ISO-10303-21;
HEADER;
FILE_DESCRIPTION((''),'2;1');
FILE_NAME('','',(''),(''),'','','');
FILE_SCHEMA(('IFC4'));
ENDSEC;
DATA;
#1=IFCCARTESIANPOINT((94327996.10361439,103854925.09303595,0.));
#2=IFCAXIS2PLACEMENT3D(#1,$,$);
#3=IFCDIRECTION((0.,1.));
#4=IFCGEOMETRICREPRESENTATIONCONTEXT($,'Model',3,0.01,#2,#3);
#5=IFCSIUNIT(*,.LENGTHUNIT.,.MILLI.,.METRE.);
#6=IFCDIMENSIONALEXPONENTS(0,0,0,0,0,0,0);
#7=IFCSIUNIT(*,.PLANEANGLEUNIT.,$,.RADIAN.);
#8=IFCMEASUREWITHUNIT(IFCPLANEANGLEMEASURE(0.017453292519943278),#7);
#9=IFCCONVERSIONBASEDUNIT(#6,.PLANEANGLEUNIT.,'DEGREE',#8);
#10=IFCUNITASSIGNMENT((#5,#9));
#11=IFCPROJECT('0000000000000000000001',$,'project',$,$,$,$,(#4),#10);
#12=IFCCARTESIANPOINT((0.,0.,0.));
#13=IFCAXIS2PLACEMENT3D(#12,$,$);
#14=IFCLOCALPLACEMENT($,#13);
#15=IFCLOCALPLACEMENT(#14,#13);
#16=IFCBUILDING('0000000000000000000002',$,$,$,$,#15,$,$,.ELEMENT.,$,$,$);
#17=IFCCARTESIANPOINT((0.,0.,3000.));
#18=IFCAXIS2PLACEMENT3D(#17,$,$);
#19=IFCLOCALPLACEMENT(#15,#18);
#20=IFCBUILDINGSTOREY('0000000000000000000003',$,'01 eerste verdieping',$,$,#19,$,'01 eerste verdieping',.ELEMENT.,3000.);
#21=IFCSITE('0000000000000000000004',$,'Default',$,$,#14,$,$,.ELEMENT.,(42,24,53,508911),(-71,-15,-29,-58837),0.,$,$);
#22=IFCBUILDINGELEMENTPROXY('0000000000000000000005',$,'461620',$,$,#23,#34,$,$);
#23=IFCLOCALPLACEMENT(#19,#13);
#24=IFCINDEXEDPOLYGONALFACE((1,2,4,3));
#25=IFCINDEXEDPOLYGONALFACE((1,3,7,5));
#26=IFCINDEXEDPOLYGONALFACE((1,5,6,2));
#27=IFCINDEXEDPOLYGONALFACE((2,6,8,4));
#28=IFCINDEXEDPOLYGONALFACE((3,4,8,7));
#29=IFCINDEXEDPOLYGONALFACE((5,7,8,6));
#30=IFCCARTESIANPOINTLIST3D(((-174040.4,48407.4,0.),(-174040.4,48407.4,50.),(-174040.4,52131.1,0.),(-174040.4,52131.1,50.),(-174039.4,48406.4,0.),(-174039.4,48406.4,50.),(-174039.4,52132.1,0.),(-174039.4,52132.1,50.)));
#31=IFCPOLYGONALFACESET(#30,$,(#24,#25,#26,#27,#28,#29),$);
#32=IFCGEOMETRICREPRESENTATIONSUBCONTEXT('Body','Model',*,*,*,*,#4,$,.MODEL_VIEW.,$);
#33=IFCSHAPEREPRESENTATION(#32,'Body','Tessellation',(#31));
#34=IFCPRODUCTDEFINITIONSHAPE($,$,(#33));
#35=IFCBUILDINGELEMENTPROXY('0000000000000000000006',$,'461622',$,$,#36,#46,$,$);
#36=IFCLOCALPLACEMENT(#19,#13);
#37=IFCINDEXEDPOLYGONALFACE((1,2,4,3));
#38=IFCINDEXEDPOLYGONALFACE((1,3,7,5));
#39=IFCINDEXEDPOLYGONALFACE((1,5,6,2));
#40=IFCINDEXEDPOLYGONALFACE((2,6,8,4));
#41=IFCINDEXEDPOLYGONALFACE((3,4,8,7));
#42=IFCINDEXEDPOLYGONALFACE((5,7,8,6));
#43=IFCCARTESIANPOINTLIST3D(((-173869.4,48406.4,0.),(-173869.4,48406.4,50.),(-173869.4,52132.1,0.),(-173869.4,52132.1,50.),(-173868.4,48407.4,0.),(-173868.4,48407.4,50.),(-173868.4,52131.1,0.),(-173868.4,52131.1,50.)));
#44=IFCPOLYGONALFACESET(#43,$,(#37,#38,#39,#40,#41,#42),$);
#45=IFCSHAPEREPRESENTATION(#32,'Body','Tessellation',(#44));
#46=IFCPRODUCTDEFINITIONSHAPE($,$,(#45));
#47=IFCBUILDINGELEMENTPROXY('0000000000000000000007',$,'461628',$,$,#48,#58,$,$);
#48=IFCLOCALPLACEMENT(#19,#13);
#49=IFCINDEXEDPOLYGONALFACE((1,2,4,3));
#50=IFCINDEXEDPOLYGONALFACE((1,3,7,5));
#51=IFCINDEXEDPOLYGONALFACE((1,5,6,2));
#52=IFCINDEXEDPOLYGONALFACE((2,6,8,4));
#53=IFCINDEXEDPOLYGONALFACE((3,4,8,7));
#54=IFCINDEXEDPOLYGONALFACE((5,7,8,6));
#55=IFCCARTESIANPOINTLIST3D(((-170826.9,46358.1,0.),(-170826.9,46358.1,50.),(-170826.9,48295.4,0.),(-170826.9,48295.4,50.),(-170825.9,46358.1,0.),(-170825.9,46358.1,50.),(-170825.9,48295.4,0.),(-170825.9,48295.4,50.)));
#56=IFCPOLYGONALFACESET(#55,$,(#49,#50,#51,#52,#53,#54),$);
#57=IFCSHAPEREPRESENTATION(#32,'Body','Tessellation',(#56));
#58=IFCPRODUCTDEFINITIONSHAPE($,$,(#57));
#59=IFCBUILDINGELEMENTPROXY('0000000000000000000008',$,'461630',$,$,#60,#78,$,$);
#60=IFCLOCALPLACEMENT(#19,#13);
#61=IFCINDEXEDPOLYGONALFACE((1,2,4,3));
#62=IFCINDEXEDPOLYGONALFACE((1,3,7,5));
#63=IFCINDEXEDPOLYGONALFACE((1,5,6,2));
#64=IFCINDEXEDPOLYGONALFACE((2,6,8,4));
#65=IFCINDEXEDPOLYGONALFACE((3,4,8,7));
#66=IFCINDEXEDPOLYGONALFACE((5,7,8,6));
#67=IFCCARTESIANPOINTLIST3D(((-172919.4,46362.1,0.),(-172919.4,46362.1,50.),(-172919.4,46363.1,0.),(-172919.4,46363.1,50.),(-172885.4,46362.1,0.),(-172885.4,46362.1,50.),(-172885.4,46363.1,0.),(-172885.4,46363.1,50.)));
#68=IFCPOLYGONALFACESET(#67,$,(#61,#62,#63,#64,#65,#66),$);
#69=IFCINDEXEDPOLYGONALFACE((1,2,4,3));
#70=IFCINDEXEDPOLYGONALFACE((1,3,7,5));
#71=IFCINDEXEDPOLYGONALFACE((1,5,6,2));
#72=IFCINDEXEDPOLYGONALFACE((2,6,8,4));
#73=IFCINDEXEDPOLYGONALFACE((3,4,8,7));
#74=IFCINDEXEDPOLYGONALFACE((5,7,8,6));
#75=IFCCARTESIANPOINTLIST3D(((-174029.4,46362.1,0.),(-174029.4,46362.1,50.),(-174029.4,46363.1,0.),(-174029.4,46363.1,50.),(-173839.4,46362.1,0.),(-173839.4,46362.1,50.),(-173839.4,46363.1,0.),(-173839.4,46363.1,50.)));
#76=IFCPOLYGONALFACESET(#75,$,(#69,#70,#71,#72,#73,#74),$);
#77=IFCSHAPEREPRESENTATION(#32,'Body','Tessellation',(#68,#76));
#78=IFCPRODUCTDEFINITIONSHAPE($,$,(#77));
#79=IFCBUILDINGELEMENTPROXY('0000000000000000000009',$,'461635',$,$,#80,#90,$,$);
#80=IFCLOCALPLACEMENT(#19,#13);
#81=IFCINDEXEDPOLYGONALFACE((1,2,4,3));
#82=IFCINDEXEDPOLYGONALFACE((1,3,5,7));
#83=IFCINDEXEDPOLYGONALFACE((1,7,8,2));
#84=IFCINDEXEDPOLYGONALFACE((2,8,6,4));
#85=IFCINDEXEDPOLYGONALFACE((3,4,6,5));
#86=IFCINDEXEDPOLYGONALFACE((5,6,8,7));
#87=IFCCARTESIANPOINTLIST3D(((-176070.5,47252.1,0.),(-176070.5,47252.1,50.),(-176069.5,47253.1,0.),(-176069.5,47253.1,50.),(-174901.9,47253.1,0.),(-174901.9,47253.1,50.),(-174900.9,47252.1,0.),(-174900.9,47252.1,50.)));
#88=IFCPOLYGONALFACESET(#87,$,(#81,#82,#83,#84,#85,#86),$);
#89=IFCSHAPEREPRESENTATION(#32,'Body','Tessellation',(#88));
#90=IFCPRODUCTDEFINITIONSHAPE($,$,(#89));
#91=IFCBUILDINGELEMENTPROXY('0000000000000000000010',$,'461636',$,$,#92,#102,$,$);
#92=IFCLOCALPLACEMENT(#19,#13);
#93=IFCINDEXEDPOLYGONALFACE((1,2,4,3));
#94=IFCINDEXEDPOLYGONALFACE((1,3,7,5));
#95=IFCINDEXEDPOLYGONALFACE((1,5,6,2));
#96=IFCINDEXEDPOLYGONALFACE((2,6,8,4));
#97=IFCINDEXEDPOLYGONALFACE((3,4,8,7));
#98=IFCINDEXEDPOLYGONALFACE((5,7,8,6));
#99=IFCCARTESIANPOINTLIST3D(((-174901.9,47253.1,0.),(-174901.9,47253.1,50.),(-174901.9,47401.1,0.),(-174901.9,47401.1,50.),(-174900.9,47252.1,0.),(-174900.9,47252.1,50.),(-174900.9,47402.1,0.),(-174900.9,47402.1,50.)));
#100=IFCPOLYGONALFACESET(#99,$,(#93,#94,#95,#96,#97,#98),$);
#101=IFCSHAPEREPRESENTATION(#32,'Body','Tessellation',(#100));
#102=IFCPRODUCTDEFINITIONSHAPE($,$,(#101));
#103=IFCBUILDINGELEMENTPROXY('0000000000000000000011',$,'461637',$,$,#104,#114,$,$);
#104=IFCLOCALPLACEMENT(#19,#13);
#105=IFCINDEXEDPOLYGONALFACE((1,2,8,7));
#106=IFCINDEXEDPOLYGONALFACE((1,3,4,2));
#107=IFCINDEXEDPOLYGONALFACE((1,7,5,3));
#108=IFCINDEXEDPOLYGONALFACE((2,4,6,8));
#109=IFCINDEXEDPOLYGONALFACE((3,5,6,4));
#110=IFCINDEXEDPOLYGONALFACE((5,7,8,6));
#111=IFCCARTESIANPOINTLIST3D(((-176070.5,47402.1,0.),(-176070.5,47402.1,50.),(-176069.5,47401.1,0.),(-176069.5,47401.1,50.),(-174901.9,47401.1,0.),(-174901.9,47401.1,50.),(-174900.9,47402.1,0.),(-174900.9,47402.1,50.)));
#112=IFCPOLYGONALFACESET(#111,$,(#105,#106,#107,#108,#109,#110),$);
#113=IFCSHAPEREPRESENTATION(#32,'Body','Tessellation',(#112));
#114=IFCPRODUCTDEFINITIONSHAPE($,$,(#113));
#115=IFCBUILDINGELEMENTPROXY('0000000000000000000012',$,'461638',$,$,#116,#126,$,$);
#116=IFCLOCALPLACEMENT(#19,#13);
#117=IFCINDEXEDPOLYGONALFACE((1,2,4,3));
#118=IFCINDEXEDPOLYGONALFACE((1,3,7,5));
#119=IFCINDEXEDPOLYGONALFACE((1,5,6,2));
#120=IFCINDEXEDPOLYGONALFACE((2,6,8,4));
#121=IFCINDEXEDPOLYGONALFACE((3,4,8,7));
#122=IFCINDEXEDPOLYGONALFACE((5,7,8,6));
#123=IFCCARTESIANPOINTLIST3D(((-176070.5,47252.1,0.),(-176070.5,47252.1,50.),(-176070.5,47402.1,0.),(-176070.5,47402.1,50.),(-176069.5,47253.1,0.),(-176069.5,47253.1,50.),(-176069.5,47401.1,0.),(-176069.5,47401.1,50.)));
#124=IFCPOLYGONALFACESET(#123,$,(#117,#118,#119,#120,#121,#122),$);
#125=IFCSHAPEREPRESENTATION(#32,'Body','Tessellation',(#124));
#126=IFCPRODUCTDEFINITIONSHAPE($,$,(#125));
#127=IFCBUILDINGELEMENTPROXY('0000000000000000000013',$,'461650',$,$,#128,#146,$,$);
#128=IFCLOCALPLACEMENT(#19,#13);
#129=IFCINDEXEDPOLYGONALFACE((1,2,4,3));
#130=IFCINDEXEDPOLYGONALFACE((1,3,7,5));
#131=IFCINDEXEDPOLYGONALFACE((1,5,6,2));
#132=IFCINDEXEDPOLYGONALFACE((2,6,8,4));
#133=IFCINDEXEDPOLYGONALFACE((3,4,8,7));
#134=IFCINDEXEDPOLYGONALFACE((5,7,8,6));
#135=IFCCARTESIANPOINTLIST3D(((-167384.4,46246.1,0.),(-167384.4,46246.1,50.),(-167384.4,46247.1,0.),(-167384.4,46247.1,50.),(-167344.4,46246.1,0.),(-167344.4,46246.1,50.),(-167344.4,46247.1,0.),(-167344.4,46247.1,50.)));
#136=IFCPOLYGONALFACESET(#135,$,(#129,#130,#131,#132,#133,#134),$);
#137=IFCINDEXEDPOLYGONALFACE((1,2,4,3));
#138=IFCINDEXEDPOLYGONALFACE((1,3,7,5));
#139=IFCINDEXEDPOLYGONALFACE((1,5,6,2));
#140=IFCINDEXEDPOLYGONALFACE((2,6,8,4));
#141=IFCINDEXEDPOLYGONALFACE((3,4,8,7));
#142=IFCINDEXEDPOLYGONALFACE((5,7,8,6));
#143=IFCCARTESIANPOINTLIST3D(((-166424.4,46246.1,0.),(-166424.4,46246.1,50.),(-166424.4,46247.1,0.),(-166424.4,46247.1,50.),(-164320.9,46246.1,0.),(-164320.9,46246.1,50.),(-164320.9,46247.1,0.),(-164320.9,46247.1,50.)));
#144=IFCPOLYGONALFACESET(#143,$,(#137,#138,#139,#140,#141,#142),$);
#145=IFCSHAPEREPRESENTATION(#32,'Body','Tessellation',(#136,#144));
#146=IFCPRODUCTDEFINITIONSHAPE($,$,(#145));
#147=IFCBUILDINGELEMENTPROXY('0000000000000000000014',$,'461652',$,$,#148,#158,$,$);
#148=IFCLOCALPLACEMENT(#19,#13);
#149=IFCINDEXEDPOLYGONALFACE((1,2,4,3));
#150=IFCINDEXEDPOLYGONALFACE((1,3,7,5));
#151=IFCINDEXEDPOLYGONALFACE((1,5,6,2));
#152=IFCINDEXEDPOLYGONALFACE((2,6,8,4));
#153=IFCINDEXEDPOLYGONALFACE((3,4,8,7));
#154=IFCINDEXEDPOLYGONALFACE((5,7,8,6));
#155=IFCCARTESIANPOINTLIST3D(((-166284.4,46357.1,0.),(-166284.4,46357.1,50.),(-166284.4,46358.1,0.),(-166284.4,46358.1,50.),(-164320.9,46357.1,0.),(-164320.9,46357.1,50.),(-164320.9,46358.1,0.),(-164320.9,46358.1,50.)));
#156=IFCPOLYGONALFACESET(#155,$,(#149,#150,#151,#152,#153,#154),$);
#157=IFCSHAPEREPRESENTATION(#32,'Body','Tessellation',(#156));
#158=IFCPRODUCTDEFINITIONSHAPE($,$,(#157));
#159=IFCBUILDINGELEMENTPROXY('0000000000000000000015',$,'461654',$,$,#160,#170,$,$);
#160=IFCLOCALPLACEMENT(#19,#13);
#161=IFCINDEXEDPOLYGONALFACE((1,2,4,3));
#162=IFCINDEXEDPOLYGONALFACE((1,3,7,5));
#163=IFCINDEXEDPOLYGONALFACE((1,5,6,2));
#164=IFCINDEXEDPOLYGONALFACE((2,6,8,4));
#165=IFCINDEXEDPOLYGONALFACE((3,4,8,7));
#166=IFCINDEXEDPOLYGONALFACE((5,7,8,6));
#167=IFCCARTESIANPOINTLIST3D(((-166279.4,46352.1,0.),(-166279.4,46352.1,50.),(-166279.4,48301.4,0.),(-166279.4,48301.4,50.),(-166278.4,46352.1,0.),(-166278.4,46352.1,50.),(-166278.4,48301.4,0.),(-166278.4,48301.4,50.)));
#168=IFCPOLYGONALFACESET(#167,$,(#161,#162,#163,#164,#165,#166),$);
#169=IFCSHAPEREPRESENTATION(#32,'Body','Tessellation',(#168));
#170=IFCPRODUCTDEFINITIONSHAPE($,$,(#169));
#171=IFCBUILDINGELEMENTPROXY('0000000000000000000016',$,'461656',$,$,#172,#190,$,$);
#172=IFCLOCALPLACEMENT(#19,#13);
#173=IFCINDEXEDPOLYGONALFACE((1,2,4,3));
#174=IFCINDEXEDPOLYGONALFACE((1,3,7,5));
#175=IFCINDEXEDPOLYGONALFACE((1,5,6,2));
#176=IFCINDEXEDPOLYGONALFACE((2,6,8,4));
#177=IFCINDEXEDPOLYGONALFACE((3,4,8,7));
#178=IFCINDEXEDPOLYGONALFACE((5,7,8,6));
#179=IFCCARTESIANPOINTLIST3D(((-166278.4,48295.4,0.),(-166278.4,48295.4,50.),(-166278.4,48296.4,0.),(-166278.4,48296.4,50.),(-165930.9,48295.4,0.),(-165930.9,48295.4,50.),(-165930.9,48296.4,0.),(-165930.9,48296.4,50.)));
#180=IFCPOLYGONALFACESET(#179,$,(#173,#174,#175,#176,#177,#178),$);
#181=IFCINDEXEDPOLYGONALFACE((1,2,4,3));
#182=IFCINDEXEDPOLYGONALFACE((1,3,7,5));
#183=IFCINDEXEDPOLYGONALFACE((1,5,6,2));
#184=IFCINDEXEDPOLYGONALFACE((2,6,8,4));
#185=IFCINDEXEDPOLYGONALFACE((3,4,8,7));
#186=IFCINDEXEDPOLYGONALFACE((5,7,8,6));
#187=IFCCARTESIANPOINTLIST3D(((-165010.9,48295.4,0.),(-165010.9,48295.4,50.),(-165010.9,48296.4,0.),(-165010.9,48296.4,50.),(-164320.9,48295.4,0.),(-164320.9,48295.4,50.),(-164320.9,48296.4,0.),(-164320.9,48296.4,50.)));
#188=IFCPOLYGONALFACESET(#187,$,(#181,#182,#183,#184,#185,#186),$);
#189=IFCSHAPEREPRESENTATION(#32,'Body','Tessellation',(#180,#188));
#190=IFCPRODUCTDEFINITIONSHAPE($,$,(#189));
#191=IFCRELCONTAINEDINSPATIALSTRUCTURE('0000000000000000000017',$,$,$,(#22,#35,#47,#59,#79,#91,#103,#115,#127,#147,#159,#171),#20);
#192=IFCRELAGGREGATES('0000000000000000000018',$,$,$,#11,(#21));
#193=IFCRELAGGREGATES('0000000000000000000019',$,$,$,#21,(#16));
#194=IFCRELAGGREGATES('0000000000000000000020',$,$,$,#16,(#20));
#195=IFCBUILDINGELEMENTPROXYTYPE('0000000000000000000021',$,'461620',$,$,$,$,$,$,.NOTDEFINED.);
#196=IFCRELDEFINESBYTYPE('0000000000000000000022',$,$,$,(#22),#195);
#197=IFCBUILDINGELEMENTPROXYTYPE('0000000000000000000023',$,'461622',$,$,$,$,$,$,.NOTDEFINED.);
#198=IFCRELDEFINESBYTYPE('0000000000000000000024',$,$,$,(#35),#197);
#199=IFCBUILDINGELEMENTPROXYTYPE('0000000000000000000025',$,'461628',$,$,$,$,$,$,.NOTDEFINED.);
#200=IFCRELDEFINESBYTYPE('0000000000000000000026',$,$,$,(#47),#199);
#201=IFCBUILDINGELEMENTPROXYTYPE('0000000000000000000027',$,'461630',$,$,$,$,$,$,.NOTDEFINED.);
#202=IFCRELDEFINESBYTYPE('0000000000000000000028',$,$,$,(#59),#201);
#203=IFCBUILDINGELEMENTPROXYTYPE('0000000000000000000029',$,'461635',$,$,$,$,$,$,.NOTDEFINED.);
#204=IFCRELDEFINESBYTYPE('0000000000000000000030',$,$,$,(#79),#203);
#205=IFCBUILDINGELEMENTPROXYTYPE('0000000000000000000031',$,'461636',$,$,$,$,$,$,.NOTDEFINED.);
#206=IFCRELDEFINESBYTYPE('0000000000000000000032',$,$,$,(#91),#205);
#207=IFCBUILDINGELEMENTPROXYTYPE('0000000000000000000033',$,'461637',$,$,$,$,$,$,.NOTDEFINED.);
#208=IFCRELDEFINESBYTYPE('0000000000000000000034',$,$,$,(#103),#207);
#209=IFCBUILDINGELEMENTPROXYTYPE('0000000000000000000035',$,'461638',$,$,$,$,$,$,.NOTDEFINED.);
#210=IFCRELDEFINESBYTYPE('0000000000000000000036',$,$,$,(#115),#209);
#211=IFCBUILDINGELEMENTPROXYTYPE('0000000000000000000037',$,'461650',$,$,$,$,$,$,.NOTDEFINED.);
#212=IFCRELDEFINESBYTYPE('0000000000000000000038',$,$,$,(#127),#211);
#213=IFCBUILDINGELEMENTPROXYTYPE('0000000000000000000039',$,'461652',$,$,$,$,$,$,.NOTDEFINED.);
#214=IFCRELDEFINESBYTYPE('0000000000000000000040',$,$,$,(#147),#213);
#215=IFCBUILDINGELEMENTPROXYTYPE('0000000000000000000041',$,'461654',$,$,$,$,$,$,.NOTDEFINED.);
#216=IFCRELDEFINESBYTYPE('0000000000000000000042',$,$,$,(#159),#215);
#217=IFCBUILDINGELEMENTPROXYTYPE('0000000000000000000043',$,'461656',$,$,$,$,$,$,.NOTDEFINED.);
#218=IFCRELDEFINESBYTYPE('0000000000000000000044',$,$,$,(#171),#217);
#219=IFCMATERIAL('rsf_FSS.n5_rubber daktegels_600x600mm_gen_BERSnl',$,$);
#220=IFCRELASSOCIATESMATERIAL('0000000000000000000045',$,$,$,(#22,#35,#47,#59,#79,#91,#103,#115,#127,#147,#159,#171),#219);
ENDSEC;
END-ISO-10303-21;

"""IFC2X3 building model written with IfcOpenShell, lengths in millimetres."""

from ifc_helpers import new_model, entity, si_unit, converted_unit, direction, frame, frame_2d, origin, origin_2d_with_axis, place, context, subcontext, project, spatial, polyline, rectangle, outline, extrude, material, type_object, element, save


model = new_model("IFC2X3")

# Units and contexts
model_context = context("Model", 3, precision=0.01, world=frame((94327996.10361439, 103854925.09303595, 0.0)), true_north=direction((0.0, 1.0)))
body_context = subcontext(model_context, "Body", "Model", "MODEL_VIEW")
ifc_project = project(units=[si_unit("LENGTHUNIT", "METRE", prefix="MILLI"), converted_unit("PLANEANGLEUNIT", "DEGREE", entity("IfcPlaneAngleMeasure", 0.017453292519943278), si_unit("PLANEANGLEUNIT", "RADIAN"), dimensions=[0, 0, 0, 0, 0, 0, 0])], contexts=[model_context])

# Site, building, storey
site_placement = place(None, origin())
site = spatial("IfcSite", under=ifc_project, at=site_placement, Name="Default", CompositionType="ELEMENT", RefLatitude=(42, 24, 53, 508911), RefLongitude=(-71, -15, -29, -58837), RefElevation=0.0)
building_placement = place(site_placement, origin())
building = spatial("IfcBuilding", under=site, at=building_placement, CompositionType="ELEMENT")
storey_placement = place(building_placement, frame((0.0, 0.0, 3000.0)))
storey = spatial("IfcBuildingStorey", under=building, at=storey_placement, Name="01 eerste verdieping", LongName="01 eerste verdieping", CompositionType="ELEMENT", Elevation=3000.0)

# Building element proxies
ifc_material = material(Name="rsf_FSS.n5_rubber daktegels_600x600mm_gen_BERSnl")
building_element_proxy_type_1 = type_object("IfcBuildingElementProxyType", Name="461620", PredefinedType="NOTDEFINED")
proxy_1_placement = place(storey_placement, origin())
element("IfcBuildingElementProxy", 1, at=proxy_1_placement, inside=storey, type_object=building_element_proxy_type_1, material=ifc_material, Name="461620", context=body_context, shape_type="SweptSolid", body=[
    extrude(outline(polyline([(-1861.8, -0.5), (1861.8, -0.5), (1862.8, 0.5), (-1862.8, 0.5), (-1861.8, -0.5)])), frame((-174039.9, 50269.2, 0.0), z_axis=(0.0, 0.0, 1.0), x_axis=(0.0, -1.0, 0.0)), (0.0, 0.0, 1.0), 50.0),
])
building_element_proxy_type_2 = type_object("IfcBuildingElementProxyType", Name="461622", PredefinedType="NOTDEFINED")
proxy_2_placement = place(storey_placement, origin())
element("IfcBuildingElementProxy", 2, at=proxy_2_placement, inside=storey, type_object=building_element_proxy_type_2, material=ifc_material, Name="461622", context=body_context, shape_type="SweptSolid", body=[
    extrude(outline(polyline([(-1861.8, -0.5), (1861.8, -0.5), (1862.8, 0.5), (-1862.8, 0.5), (-1861.8, -0.5)])), frame((-173868.9, 50269.2, 0.0), z_axis=(0.0, 0.0, 1.0), x_axis=(0.0, 1.0, 0.0)), (0.0, 0.0, 1.0), 50.0),
])
building_element_proxy_type_3 = type_object("IfcBuildingElementProxyType", Name="461628", PredefinedType="NOTDEFINED")
proxy_3_placement = place(storey_placement, origin())
element("IfcBuildingElementProxy", 3, at=proxy_3_placement, inside=storey, type_object=building_element_proxy_type_3, material=ifc_material, Name="461628", context=body_context, shape_type="SweptSolid", body=[
    extrude(rectangle(XDim=1937.4, YDim=1.0, at=frame_2d((0.0, 0.0), x_axis=(1.0, 0.0))), frame((-170826.4, 47326.7, 0.0), z_axis=(0.0, 0.0, 1.0), x_axis=(0.0, -1.0, 0.0)), (0.0, 0.0, 1.0), 50.0),
])
building_element_proxy_type_4 = type_object("IfcBuildingElementProxyType", Name="461630", PredefinedType="NOTDEFINED")
proxy_4_placement = place(storey_placement, origin())
element("IfcBuildingElementProxy", 4, at=proxy_4_placement, inside=storey, type_object=building_element_proxy_type_4, material=ifc_material, Name="461630", context=body_context, shape_type="SweptSolid", body=[
    extrude(rectangle(XDim=34.0, YDim=1.0, at=frame_2d((0.0, 0.0), x_axis=(1.0, 0.0))), frame((-172902.4, 46362.6, 0.0), z_axis=(0.0, 0.0, 1.0), x_axis=(-1.0, 0.0, 0.0)), (0.0, 0.0, 1.0), 50.0),
    extrude(rectangle(XDim=190.0, YDim=1.0, at=origin_2d_with_axis()), frame((-173934.4, 46362.6, 0.0), z_axis=(0.0, 0.0, 1.0), x_axis=(-1.0, 0.0, 0.0)), (0.0, 0.0, 1.0), 50.0),
])
building_element_proxy_type_5 = type_object("IfcBuildingElementProxyType", Name="461635", PredefinedType="NOTDEFINED")
proxy_5_placement = place(storey_placement, origin())
element("IfcBuildingElementProxy", 5, at=proxy_5_placement, inside=storey, type_object=building_element_proxy_type_5, material=ifc_material, Name="461635", context=body_context, shape_type="SweptSolid", body=[
    extrude(outline(polyline([(-583.8, -0.5), (583.8, -0.5), (584.8, 0.5), (-584.8, 0.5), (-583.8, -0.5)])), frame((-175485.7, 47252.6, 0.0), z_axis=(0.0, 0.0, 1.0), x_axis=(-1.0, 0.0, 0.0)), (0.0, 0.0, 1.0), 50.0),
])
building_element_proxy_type_6 = type_object("IfcBuildingElementProxyType", Name="461636", PredefinedType="NOTDEFINED")
proxy_6_placement = place(storey_placement, origin())
element("IfcBuildingElementProxy", 6, at=proxy_6_placement, inside=storey, type_object=building_element_proxy_type_6, material=ifc_material, Name="461636", context=body_context, shape_type="SweptSolid", body=[
    extrude(outline(polyline([(-74.0, -0.5), (74.0, -0.5), (75.0, 0.5), (-75.0, 0.5), (-74.0, -0.5)])), frame((-174901.4, 47327.1, 0.0), z_axis=(0.0, 0.0, 1.0), x_axis=(0.0, -1.0, 0.0)), (0.0, 0.0, 1.0), 50.0),
])
building_element_proxy_type_7 = type_object("IfcBuildingElementProxyType", Name="461637", PredefinedType="NOTDEFINED")
proxy_7_placement = place(storey_placement, origin())
element("IfcBuildingElementProxy", 7, at=proxy_7_placement, inside=storey, type_object=building_element_proxy_type_7, material=ifc_material, Name="461637", context=body_context, shape_type="SweptSolid", body=[
    extrude(outline(polyline([(-583.8, -0.5), (583.8, -0.5), (584.8, 0.5), (-584.8, 0.5), (-583.8, -0.5)])), frame((-175485.7, 47401.6, 0.0)), (0.0, 0.0, 1.0), 50.0),
])
building_element_proxy_type_8 = type_object("IfcBuildingElementProxyType", Name="461638", PredefinedType="NOTDEFINED")
proxy_8_placement = place(storey_placement, origin())
element("IfcBuildingElementProxy", 8, at=proxy_8_placement, inside=storey, type_object=building_element_proxy_type_8, material=ifc_material, Name="461638", context=body_context, shape_type="SweptSolid", body=[
    extrude(outline(polyline([(-74.0, -0.5), (74.0, -0.5), (75.0, 0.5), (-75.0, 0.5), (-74.0, -0.5)])), frame((-176070.0, 47327.1, 0.0), z_axis=(0.0, 0.0, 1.0), x_axis=(0.0, 1.0, 0.0)), (0.0, 0.0, 1.0), 50.0),
])
building_element_proxy_type_9 = type_object("IfcBuildingElementProxyType", Name="461650", PredefinedType="NOTDEFINED")
proxy_9_placement = place(storey_placement, origin())
element("IfcBuildingElementProxy", 9, at=proxy_9_placement, inside=storey, type_object=building_element_proxy_type_9, material=ifc_material, Name="461650", context=body_context, shape_type="SweptSolid", body=[
    extrude(rectangle(XDim=40.0, YDim=1.0, at=frame_2d((0.0, 0.0), x_axis=(1.0, 0.0))), frame((-167364.4, 46246.6, 0.0)), (0.0, 0.0, 1.0), 50.0),
    extrude(rectangle(XDim=2103.5, YDim=1.0, at=frame_2d((0.0, 0.0), x_axis=(1.0, 0.0))), frame((-165372.6, 46246.6, 0.0)), (0.0, 0.0, 1.0), 50.0),
])
building_element_proxy_type_10 = type_object("IfcBuildingElementProxyType", Name="461652", PredefinedType="NOTDEFINED")
proxy_10_placement = place(storey_placement, origin())
element("IfcBuildingElementProxy", 10, at=proxy_10_placement, inside=storey, type_object=building_element_proxy_type_10, material=ifc_material, Name="461652", context=body_context, shape_type="SweptSolid", body=[
    extrude(rectangle(XDim=1963.5, YDim=1.0, at=frame_2d((0.0, 0.0), x_axis=(1.0, 0.0))), frame((-165302.6, 46357.6, 0.0), z_axis=(0.0, 0.0, 1.0), x_axis=(-1.0, 0.0, 0.0)), (0.0, 0.0, 1.0), 50.0),
])
building_element_proxy_type_11 = type_object("IfcBuildingElementProxyType", Name="461654", PredefinedType="NOTDEFINED")
proxy_11_placement = place(storey_placement, origin())
element("IfcBuildingElementProxy", 11, at=proxy_11_placement, inside=storey, type_object=building_element_proxy_type_11, material=ifc_material, Name="461654", context=body_context, shape_type="SweptSolid", body=[
    extrude(rectangle(XDim=1949.4, YDim=1.0, at=frame_2d((0.0, 0.0), x_axis=(1.0, 0.0))), frame((-166278.9, 47326.7, 0.0), z_axis=(0.0, 0.0, 1.0), x_axis=(0.0, 1.0, 0.0)), (0.0, 0.0, 1.0), 50.0),
])
building_element_proxy_type_12 = type_object("IfcBuildingElementProxyType", Name="461656", PredefinedType="NOTDEFINED")
proxy_12_placement = place(storey_placement, origin())
element("IfcBuildingElementProxy", 12, at=proxy_12_placement, inside=storey, type_object=building_element_proxy_type_12, material=ifc_material, Name="461656", context=body_context, shape_type="SweptSolid", body=[
    extrude(rectangle(XDim=347.5, YDim=1.0, at=frame_2d((0.0, 0.0), x_axis=(1.0, 0.0))), frame((-166104.6, 48295.9, 0.0)), (0.0, 0.0, 1.0), 50.0),
    extrude(rectangle(XDim=690.0, YDim=1.0, at=frame_2d((0.0, 0.0), x_axis=(1.0, 0.0))), frame((-164665.9, 48295.9, 0.0)), (0.0, 0.0, 1.0), 50.0),
])

save(model, "model.ifc")
